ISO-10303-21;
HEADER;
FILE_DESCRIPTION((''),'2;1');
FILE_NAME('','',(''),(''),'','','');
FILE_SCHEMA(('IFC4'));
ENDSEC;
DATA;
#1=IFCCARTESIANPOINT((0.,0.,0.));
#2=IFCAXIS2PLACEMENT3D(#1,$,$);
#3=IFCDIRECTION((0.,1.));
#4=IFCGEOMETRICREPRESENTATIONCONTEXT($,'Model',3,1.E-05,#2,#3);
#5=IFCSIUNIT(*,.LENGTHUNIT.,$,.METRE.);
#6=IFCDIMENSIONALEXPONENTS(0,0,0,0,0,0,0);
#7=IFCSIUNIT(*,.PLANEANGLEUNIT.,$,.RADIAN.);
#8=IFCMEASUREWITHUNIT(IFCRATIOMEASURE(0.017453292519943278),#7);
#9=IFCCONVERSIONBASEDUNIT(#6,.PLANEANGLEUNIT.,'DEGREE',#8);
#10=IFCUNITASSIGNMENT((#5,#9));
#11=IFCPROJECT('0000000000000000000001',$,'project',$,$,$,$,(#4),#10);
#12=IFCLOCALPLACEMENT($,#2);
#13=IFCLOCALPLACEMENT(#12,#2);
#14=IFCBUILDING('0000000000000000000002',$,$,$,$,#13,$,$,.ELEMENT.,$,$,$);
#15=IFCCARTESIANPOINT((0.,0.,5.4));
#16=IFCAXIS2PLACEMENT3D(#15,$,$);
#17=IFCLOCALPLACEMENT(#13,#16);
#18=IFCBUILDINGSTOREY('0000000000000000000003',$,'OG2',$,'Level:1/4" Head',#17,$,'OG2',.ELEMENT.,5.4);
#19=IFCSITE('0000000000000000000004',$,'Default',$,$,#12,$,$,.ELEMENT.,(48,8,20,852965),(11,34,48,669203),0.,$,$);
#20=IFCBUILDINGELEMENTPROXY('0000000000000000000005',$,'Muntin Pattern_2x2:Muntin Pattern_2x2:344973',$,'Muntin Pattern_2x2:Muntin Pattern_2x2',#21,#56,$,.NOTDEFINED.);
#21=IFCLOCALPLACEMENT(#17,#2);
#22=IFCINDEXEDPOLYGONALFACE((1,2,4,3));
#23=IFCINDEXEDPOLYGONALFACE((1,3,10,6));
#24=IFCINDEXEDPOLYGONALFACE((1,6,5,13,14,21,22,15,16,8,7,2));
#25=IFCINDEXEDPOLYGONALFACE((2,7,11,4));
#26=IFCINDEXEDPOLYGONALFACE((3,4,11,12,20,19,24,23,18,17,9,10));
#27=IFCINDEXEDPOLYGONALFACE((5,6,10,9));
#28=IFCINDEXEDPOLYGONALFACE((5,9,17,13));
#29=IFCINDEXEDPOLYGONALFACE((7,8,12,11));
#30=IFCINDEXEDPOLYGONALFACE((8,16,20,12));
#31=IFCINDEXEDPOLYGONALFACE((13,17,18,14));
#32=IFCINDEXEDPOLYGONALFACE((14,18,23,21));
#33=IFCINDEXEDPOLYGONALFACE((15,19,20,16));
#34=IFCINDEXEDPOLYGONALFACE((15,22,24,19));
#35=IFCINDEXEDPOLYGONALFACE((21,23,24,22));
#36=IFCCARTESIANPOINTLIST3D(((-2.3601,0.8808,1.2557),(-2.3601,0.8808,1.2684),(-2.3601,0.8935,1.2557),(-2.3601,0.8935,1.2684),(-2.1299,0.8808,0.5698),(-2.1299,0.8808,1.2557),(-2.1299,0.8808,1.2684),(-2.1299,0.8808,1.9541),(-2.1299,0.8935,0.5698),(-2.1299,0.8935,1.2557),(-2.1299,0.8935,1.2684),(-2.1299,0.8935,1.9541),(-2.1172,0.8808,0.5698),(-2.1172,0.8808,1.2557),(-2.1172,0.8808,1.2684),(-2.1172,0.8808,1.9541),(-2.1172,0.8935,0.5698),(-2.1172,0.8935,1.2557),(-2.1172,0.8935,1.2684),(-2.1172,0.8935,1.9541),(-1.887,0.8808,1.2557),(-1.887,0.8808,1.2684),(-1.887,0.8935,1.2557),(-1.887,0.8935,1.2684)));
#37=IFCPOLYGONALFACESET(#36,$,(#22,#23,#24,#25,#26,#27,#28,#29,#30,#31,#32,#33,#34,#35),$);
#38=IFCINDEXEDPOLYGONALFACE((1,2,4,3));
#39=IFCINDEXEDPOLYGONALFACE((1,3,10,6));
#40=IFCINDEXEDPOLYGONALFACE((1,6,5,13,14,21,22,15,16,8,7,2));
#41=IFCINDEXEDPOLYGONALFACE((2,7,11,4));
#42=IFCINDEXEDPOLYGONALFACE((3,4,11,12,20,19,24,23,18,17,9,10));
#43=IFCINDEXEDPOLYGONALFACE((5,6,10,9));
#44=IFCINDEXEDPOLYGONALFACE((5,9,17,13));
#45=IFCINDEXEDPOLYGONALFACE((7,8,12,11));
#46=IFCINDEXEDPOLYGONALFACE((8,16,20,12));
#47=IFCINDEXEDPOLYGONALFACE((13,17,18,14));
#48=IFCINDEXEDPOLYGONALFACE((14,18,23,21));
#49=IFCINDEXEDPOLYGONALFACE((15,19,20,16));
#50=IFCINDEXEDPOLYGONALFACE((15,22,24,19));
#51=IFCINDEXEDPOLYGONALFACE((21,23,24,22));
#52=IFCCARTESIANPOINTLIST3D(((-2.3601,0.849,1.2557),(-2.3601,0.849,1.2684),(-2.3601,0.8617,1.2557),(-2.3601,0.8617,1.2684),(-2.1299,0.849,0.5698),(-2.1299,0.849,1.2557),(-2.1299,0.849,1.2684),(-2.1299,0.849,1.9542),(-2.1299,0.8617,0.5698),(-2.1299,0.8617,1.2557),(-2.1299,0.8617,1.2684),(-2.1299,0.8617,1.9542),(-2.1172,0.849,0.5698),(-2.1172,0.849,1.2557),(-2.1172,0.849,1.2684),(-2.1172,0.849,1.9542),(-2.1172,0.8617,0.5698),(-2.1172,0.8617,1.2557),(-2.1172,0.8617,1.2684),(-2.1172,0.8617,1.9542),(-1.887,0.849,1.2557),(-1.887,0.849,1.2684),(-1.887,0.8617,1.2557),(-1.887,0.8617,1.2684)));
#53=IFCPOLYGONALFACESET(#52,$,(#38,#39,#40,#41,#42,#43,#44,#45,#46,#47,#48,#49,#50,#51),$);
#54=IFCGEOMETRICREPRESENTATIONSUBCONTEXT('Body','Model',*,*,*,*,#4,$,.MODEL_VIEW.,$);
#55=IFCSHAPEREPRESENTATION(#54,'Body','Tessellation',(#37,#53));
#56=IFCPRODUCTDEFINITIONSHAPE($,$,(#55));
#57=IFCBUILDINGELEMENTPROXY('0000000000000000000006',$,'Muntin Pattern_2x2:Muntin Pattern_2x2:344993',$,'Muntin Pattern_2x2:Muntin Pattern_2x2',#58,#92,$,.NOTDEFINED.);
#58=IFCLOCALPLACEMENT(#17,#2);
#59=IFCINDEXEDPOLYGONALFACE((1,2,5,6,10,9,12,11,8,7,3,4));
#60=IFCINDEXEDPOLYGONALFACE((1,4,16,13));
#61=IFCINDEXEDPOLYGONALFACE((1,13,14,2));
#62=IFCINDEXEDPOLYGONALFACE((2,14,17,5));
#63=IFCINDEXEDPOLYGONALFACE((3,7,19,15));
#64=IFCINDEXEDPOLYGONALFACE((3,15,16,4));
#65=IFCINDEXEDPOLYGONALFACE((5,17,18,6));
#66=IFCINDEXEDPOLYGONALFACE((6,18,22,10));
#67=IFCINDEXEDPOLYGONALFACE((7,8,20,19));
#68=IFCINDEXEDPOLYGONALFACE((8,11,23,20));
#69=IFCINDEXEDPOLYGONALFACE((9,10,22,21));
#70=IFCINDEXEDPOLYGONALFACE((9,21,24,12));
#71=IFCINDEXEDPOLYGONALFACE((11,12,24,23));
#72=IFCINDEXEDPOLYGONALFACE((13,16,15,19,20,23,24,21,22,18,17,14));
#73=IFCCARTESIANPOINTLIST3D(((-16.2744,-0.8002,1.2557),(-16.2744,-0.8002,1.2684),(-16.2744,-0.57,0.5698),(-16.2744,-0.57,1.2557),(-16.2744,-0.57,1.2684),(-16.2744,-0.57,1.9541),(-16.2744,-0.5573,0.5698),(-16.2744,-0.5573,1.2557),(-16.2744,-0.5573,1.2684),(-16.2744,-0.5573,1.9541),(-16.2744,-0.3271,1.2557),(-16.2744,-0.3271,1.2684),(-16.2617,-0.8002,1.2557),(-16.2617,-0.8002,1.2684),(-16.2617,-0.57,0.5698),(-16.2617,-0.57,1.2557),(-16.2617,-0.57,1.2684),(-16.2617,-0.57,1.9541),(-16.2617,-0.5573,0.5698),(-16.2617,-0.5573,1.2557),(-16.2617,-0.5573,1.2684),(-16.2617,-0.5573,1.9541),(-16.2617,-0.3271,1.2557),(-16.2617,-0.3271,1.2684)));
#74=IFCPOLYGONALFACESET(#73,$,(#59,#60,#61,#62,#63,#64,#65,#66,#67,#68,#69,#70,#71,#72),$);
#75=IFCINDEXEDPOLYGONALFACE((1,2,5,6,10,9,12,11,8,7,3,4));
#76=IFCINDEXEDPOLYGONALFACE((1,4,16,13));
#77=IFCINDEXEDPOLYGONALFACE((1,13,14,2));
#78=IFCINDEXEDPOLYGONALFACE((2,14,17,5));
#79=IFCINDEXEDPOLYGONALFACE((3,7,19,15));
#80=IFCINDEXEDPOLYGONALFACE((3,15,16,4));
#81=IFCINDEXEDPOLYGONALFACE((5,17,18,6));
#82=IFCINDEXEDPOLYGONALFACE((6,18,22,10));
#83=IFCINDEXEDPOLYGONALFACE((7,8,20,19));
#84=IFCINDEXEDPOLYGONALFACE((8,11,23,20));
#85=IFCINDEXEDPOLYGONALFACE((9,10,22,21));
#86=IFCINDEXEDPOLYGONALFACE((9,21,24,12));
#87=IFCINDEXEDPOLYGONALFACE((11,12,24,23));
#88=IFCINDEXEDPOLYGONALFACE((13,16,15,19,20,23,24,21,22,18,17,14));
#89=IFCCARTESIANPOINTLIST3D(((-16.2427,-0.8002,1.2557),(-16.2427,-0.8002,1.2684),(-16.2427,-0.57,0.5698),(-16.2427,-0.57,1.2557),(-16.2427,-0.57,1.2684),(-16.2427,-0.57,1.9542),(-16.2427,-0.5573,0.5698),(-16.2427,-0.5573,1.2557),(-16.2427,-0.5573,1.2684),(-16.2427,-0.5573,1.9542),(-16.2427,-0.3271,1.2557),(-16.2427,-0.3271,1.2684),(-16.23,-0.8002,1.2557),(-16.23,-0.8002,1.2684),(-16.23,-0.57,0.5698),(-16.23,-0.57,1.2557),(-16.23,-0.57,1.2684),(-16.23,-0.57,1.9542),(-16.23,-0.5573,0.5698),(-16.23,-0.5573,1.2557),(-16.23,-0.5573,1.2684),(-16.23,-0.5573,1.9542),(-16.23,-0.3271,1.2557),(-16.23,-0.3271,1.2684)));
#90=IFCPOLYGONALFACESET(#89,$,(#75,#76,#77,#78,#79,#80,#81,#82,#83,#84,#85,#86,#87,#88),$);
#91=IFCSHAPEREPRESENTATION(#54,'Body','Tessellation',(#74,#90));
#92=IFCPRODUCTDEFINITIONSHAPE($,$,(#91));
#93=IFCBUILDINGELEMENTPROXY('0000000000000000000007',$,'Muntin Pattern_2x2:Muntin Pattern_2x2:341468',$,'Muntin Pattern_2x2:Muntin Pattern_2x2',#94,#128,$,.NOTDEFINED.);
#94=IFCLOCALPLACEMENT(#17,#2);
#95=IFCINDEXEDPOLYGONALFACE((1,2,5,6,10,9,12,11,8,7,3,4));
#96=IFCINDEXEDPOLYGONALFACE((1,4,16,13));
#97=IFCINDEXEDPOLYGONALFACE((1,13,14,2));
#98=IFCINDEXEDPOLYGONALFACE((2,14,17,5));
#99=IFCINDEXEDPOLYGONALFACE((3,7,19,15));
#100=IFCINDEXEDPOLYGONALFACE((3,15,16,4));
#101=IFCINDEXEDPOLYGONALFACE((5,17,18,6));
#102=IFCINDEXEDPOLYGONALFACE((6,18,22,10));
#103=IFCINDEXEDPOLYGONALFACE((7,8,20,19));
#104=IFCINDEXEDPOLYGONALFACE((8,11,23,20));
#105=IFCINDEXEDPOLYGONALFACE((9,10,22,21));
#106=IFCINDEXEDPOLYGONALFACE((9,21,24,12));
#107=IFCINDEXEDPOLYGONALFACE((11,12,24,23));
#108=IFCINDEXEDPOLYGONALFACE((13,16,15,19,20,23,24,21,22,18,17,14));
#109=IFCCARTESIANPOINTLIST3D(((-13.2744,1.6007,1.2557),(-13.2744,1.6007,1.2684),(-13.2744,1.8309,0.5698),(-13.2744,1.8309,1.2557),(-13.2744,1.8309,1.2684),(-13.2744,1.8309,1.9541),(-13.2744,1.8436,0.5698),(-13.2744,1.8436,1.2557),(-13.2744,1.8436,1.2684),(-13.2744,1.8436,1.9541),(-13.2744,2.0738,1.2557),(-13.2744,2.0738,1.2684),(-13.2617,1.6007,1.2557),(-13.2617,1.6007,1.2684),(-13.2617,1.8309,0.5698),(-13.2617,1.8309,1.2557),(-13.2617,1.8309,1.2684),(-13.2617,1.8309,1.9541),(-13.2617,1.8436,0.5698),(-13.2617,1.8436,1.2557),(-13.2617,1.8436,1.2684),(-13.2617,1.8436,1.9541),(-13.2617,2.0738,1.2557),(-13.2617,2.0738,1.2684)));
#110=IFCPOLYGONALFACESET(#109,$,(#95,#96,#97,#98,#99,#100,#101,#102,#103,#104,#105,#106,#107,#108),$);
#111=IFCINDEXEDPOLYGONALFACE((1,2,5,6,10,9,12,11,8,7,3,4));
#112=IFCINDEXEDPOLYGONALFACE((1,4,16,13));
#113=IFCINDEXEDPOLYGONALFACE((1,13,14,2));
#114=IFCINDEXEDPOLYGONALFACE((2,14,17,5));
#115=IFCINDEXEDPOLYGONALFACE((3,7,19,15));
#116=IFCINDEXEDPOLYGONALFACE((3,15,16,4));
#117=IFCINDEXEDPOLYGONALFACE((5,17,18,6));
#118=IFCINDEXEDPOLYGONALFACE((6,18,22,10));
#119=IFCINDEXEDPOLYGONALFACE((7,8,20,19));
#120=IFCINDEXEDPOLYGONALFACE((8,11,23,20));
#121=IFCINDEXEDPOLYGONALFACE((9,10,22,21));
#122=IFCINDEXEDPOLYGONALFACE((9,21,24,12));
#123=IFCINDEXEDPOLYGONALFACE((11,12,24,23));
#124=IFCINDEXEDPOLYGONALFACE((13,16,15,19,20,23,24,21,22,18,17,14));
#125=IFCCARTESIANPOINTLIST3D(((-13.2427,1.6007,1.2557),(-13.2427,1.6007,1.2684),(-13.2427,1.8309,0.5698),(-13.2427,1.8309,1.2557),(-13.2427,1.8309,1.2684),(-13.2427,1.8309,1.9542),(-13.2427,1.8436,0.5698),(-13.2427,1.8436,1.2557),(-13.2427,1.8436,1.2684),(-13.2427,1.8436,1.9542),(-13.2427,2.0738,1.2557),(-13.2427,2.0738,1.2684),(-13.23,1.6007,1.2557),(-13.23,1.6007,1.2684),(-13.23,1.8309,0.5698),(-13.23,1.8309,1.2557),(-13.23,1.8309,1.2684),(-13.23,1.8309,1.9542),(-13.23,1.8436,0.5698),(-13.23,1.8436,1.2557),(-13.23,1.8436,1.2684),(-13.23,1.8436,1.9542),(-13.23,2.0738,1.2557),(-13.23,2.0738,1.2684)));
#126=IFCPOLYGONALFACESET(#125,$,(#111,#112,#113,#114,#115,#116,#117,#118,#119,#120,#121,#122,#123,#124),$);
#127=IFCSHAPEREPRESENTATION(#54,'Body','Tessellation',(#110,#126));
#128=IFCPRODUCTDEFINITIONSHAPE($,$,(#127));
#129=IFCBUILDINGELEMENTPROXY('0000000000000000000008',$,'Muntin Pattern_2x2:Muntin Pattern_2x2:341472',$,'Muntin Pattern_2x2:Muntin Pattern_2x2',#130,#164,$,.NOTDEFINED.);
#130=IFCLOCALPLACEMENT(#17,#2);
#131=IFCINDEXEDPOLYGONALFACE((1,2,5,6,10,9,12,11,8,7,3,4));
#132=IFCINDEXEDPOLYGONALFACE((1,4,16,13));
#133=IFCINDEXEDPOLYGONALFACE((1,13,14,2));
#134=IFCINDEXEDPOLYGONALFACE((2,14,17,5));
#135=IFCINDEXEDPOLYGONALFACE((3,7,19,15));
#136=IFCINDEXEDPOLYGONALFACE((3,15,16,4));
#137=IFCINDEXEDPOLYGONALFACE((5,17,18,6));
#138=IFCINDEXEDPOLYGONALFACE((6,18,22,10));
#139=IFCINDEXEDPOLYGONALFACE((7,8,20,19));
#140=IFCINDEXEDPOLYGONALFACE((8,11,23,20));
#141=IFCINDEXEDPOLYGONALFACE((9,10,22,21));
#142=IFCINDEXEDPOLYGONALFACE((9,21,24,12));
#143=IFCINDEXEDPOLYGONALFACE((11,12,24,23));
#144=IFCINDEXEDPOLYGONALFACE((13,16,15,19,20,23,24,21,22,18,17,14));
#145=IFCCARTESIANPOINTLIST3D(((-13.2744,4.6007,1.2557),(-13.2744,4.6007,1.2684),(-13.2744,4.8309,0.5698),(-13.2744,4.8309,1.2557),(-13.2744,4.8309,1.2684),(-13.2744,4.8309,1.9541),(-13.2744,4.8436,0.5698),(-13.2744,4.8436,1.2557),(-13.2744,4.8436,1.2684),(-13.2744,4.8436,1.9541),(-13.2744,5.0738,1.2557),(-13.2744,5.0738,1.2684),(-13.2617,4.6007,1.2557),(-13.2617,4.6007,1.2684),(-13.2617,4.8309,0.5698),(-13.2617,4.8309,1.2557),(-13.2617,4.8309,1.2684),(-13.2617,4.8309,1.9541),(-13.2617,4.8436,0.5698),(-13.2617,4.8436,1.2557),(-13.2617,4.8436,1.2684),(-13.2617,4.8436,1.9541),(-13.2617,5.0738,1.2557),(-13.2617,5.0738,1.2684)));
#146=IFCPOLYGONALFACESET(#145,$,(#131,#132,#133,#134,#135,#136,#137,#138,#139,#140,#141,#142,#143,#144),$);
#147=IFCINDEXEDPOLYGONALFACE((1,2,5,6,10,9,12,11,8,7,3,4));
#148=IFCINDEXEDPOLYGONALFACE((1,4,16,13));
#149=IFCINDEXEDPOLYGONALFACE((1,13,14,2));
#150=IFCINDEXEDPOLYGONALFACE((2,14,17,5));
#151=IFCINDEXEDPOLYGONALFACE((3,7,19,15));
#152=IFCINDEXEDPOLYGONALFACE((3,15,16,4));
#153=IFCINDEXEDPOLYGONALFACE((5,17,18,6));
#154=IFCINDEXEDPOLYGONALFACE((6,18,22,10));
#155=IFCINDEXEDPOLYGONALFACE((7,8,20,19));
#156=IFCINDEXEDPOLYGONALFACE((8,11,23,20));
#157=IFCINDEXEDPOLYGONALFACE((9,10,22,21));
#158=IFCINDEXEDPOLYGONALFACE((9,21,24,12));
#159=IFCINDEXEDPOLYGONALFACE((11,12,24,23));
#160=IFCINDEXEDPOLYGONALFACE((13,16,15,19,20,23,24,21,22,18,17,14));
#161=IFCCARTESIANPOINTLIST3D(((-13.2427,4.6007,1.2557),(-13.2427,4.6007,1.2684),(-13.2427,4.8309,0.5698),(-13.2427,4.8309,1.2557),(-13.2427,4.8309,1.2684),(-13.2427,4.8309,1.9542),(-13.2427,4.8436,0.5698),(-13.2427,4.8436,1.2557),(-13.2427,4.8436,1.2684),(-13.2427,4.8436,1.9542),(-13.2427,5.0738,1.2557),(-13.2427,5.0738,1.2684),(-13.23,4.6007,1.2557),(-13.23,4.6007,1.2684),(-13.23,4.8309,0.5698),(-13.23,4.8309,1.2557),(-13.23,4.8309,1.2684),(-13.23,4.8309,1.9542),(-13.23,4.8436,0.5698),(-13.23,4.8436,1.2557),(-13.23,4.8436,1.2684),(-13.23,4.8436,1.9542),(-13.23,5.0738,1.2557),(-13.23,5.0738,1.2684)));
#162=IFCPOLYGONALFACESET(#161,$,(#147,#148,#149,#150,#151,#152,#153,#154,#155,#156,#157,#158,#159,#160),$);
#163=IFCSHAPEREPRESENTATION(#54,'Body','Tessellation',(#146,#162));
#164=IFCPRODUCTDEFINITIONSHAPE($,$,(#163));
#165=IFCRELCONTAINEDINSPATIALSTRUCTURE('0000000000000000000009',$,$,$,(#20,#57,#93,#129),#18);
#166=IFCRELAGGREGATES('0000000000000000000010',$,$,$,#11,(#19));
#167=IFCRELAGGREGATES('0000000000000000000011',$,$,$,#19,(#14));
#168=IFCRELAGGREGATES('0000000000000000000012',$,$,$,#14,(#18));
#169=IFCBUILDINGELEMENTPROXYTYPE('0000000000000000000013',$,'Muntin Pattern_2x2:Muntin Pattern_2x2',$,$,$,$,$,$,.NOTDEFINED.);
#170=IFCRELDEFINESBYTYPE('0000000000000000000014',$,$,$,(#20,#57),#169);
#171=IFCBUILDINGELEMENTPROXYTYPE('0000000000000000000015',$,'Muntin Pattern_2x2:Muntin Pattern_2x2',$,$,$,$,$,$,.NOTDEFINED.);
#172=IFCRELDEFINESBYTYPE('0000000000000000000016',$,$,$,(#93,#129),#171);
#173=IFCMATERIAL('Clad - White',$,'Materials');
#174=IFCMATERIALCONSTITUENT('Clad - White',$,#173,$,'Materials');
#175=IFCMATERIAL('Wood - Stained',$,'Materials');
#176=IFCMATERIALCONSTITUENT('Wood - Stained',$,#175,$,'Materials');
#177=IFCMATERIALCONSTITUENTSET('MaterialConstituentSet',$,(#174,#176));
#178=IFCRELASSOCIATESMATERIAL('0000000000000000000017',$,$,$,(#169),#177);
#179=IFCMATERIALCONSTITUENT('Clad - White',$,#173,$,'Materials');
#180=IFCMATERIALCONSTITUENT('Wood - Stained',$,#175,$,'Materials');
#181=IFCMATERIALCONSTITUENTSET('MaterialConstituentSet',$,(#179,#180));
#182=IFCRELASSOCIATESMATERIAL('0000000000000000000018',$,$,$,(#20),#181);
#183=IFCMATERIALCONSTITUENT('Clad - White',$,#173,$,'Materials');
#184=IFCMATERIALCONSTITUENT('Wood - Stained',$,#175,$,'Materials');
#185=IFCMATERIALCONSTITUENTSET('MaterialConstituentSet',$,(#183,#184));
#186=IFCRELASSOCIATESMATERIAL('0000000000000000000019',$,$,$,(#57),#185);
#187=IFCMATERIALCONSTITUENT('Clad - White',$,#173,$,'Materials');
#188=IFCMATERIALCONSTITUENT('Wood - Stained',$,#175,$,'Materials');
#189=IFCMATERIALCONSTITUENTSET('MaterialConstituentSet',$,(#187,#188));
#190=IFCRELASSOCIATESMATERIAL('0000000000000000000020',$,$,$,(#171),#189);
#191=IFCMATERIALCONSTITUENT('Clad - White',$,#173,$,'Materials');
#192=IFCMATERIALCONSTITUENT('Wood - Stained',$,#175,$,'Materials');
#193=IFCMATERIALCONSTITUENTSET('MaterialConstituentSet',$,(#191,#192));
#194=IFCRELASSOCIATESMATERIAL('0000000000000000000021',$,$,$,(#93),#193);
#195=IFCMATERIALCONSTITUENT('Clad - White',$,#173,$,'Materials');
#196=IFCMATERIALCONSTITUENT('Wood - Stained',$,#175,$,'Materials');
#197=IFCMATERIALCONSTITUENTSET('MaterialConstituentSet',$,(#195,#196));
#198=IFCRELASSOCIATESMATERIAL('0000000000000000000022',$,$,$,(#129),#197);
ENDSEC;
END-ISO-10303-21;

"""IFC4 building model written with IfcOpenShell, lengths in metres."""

from ifc_helpers import new_model, entity, si_unit, converted_unit, direction, frame, origin, place, context, subcontext, project, spatial, indexed_curve, outline, extrude, source, transform, mapped, material, constituent, constituent_set, type_object, type_shapes, element, save


model = new_model("IFC4")

# Units and contexts
model_context = context("Model", 3, precision=1e-05, world=origin(), true_north=direction((0.0, 1.0)))
body_context = subcontext(model_context, "Body", "Model", "MODEL_VIEW")
ifc_project = project(units=[si_unit("LENGTHUNIT", "METRE"), converted_unit("PLANEANGLEUNIT", "DEGREE", entity("IfcRatioMeasure", 0.017453292519943278), si_unit("PLANEANGLEUNIT", "RADIAN"), dimensions=[0, 0, 0, 0, 0, 0, 0])], contexts=[model_context])

# Site, building, storey
site_placement = place(None, origin())
site = spatial("IfcSite", under=ifc_project, at=site_placement, Name="Default", CompositionType="ELEMENT", RefLatitude=(48, 8, 20, 852965), RefLongitude=(11, 34, 48, 669203), RefElevation=0.0)
building_placement = place(site_placement, origin())
building = spatial("IfcBuilding", under=site, at=building_placement, CompositionType="ELEMENT")
storey_placement = place(building_placement, frame((0.0, 0.0, 5.4)))
storey = spatial("IfcBuildingStorey", under=building, at=storey_placement, Name="OG2", ObjectType="Level:1/4\" Head", LongName="OG2", CompositionType="ELEMENT", Elevation=5.4)

# Building element proxies
ifc_material_1 = material(Name="Clad - White", Category="Materials")
ifc_material_2 = material(Name="Wood - Stained", Category="Materials")
ifc_constituent_1 = constituent(ifc_material_1, Name="Clad - White", Category="Materials")
ifc_constituent_2 = constituent(ifc_material_2, Name="Wood - Stained", Category="Materials")
ifc_constituent_set_1 = constituent_set(constituents=[ifc_constituent_1, ifc_constituent_2], Name="MaterialConstituentSet")
building_element_proxy_type_1 = type_object("IfcBuildingElementProxyType", Name="Muntin Pattern_2x2:Muntin Pattern_2x2", PredefinedType="NOTDEFINED", material=ifc_constituent_set_1)
shared_shape_1 = source(origin(), body_context, "Body", "SweptSolid", [
    extrude(outline(indexed_curve([(0.0064, -0.0064), (0.6921, -0.0064), (0.6921, 0.0063), (0.0064, 0.0063), (0.0064, 0.2365), (-0.0063, 0.2365), (-0.0063, 0.0063), (-0.6922, 0.0063), (-0.6922, -0.0064), (-0.0063, -0.0064), (-0.0063, -0.2365), (0.0064, -0.2365), (0.0064, -0.0064)], self_intersect=False)), frame((0.0, -0.0222, 0.6921), z_axis=(0.0, 1.0, 0.0), x_axis=(0.0, 0.0, 1.0)), (0.0, 0.0, 1.0), 0.0127),
    extrude(outline(indexed_curve([(0.0064, -0.0064), (0.6922, -0.0064), (0.6922, 0.0063), (0.0064, 0.0063), (0.0064, 0.2365), (-0.0063, 0.2365), (-0.0063, 0.0063), (-0.6922, 0.0063), (-0.6922, -0.0064), (-0.0063, -0.0064), (-0.0063, -0.2365), (0.0064, -0.2365), (0.0064, -0.0064)], self_intersect=False)), frame((0.0, 0.0095, 0.6922), z_axis=(0.0, 1.0, 0.0), x_axis=(0.0, 0.0, 1.0)), (0.0, 0.0, 1.0), 0.0127),
])
type_shapes(building_element_proxy_type_1, [shared_shape_1])
ifc_constituent_3 = constituent(ifc_material_1, Name="Clad - White", Category="Materials")
ifc_constituent_4 = constituent(ifc_material_2, Name="Wood - Stained", Category="Materials")
ifc_constituent_set_2 = constituent_set(constituents=[ifc_constituent_3, ifc_constituent_4], Name="MaterialConstituentSet")
proxy_1_placement = place(storey_placement, frame((-2.1235, 0.8713, 0.5699), z_axis=(0.0, 0.0, 1.0), x_axis=(-1.0, 0.0, 0.0)))
element("IfcBuildingElementProxy", 1, at=proxy_1_placement, inside=storey, type_object=building_element_proxy_type_1, material=ifc_constituent_set_2, Name="Muntin Pattern_2x2:Muntin Pattern_2x2:344973", ObjectType="Muntin Pattern_2x2:Muntin Pattern_2x2", PredefinedType="NOTDEFINED", context=body_context, shape_type="MappedRepresentation", body=[
    mapped(shared_shape_1, transform((0.0, 0.0, 0.0), scale=1.0)),
])
ifc_constituent_5 = constituent(ifc_material_1, Name="Clad - White", Category="Materials")
ifc_constituent_6 = constituent(ifc_material_2, Name="Wood - Stained", Category="Materials")
ifc_constituent_set_3 = constituent_set(constituents=[ifc_constituent_5, ifc_constituent_6], Name="MaterialConstituentSet")
proxy_2_placement = place(storey_placement, frame((-16.2522, -0.5636, 0.5699), z_axis=(0.0, 0.0, 1.0), x_axis=(0.0, -1.0, 0.0)))
element("IfcBuildingElementProxy", 2, at=proxy_2_placement, inside=storey, type_object=building_element_proxy_type_1, material=ifc_constituent_set_3, Name="Muntin Pattern_2x2:Muntin Pattern_2x2:344993", ObjectType="Muntin Pattern_2x2:Muntin Pattern_2x2", PredefinedType="NOTDEFINED", context=body_context, shape_type="MappedRepresentation", body=[
    mapped(shared_shape_1, transform((0.0, 0.0, 0.0), scale=1.0)),
])
ifc_constituent_7 = constituent(ifc_material_1, Name="Clad - White", Category="Materials")
ifc_constituent_8 = constituent(ifc_material_2, Name="Wood - Stained", Category="Materials")
ifc_constituent_set_4 = constituent_set(constituents=[ifc_constituent_7, ifc_constituent_8], Name="MaterialConstituentSet")
ifc_constituent_9 = constituent(ifc_material_1, Name="Clad - White", Category="Materials")
ifc_constituent_10 = constituent(ifc_material_2, Name="Wood - Stained", Category="Materials")
ifc_constituent_set_5 = constituent_set(constituents=[ifc_constituent_9, ifc_constituent_10], Name="MaterialConstituentSet")
building_element_proxy_type_2 = type_object("IfcBuildingElementProxyType", Name="Muntin Pattern_2x2:Muntin Pattern_2x2", PredefinedType="NOTDEFINED", material=ifc_constituent_set_5)
shared_shape_2 = source(origin(), body_context, "Body", "SweptSolid", [
    extrude(outline(indexed_curve([(0.0064, -0.0064), (0.6921, -0.0064), (0.6921, 0.0063), (0.0064, 0.0063), (0.0064, 0.2365), (-0.0063, 0.2365), (-0.0063, 0.0063), (-0.6922, 0.0063), (-0.6922, -0.0064), (-0.0063, -0.0064), (-0.0063, -0.2365), (0.0064, -0.2365), (0.0064, -0.0064)], self_intersect=False)), frame((0.0, 0.0095, 0.6921), z_axis=(0.0, 1.0, 0.0), x_axis=(0.0, 0.0, 1.0)), (0.0, 0.0, 1.0), 0.0127),
    extrude(outline(indexed_curve([(0.0064, -0.0064), (0.6922, -0.0064), (0.6922, 0.0063), (0.0064, 0.0063), (0.0064, 0.2365), (-0.0063, 0.2365), (-0.0063, 0.0063), (-0.6922, 0.0063), (-0.6922, -0.0064), (-0.0063, -0.0064), (-0.0063, -0.2365), (0.0064, -0.2365), (0.0064, -0.0064)], self_intersect=False)), frame((0.0, -0.0222, 0.6922), z_axis=(0.0, 1.0, 0.0), x_axis=(0.0, 0.0, 1.0)), (0.0, 0.0, 1.0), 0.0127),
])
type_shapes(building_element_proxy_type_2, [shared_shape_2])
proxy_3_placement = place(storey_placement, frame((-13.2522, 1.8372, 0.5699), z_axis=(0.0, 0.0, 1.0), x_axis=(0.0, 1.0, 0.0)))
element("IfcBuildingElementProxy", 3, at=proxy_3_placement, inside=storey, type_object=building_element_proxy_type_2, material=ifc_constituent_set_4, Name="Muntin Pattern_2x2:Muntin Pattern_2x2:341468", ObjectType="Muntin Pattern_2x2:Muntin Pattern_2x2", PredefinedType="NOTDEFINED", context=body_context, shape_type="MappedRepresentation", body=[
    mapped(shared_shape_2, transform((0.0, 0.0, 0.0), scale=1.0)),
])
ifc_constituent_11 = constituent(ifc_material_1, Name="Clad - White", Category="Materials")
ifc_constituent_12 = constituent(ifc_material_2, Name="Wood - Stained", Category="Materials")
ifc_constituent_set_6 = constituent_set(constituents=[ifc_constituent_11, ifc_constituent_12], Name="MaterialConstituentSet")
proxy_4_placement = place(storey_placement, frame((-13.2522, 4.8372, 0.5699), z_axis=(0.0, 0.0, 1.0), x_axis=(0.0, 1.0, 0.0)))
element("IfcBuildingElementProxy", 4, at=proxy_4_placement, inside=storey, type_object=building_element_proxy_type_2, material=ifc_constituent_set_6, Name="Muntin Pattern_2x2:Muntin Pattern_2x2:341472", ObjectType="Muntin Pattern_2x2:Muntin Pattern_2x2", PredefinedType="NOTDEFINED", context=body_context, shape_type="MappedRepresentation", body=[
    mapped(shared_shape_2, transform((0.0, 0.0, 0.0), scale=1.0)),
])

save(model, "model.ifc")
